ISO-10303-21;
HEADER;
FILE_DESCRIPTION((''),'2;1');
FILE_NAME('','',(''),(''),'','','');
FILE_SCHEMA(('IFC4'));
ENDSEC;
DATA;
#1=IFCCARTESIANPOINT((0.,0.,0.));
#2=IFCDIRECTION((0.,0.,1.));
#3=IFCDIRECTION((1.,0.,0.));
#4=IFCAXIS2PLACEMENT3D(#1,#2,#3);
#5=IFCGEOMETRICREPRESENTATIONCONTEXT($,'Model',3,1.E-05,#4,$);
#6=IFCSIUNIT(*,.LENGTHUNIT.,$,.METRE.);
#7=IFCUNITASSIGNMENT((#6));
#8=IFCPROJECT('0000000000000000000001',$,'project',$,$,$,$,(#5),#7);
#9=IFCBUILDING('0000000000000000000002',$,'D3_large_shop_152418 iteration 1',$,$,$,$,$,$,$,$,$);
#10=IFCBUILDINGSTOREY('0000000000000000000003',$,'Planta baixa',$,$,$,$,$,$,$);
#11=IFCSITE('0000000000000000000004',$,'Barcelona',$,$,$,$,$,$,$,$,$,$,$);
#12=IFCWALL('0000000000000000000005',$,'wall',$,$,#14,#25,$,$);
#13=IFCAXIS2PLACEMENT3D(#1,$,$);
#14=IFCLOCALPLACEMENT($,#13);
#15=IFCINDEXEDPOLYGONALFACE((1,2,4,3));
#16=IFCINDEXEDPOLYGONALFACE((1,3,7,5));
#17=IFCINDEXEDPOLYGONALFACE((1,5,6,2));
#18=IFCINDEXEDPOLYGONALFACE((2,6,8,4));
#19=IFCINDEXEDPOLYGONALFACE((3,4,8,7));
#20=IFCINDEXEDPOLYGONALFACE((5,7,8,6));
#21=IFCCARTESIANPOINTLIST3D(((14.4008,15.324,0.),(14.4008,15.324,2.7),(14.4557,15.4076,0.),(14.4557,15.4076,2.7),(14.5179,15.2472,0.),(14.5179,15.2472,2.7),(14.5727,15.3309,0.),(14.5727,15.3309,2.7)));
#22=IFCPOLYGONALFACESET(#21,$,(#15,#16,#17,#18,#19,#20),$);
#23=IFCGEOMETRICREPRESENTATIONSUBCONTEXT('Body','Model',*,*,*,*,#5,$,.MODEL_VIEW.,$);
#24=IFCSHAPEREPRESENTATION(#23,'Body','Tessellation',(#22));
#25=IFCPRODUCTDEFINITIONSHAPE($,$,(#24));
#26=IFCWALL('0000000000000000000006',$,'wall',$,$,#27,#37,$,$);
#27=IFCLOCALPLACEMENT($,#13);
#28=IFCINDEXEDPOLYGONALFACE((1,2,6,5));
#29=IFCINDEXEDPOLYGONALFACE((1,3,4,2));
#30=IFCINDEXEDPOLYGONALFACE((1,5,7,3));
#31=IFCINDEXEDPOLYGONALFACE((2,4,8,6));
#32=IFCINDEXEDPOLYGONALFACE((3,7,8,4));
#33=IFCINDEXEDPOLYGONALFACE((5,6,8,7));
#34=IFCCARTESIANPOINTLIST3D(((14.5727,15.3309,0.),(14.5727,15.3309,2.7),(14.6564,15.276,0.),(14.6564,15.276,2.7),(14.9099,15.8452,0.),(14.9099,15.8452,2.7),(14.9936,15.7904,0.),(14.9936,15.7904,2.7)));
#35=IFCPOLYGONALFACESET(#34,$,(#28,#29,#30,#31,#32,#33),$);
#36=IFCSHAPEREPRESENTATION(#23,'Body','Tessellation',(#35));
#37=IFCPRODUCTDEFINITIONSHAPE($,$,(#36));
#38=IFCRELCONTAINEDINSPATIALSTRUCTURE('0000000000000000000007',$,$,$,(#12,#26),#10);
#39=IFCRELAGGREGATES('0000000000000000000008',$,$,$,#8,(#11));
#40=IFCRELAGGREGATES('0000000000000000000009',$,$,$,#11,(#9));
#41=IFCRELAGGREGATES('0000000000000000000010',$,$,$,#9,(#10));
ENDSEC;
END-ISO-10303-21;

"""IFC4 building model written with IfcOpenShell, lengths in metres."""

from ifc_helpers import new_model, si_unit, origin, origin_with_axes, place, context, subcontext, project, spatial, polyline, outline, extrude, element, save


model = new_model("IFC4")

# Units and contexts
model_context = context("Model", 3, precision=1e-05, world=origin_with_axes())
body_context = subcontext(model_context, "Body", "Model", "MODEL_VIEW")
ifc_project = project(units=[si_unit("LENGTHUNIT", "METRE")], contexts=[model_context])

# Site, building, storey
site = spatial("IfcSite", under=ifc_project, Name="Barcelona")
building = spatial("IfcBuilding", under=site, Name="D3_large_shop_152418 iteration 1")
storey = spatial("IfcBuildingStorey", under=building, Name="Planta baixa")

# Walls
wall_1_placement = place(None, origin_with_axes())
element("IfcWall", 1, at=wall_1_placement, inside=storey, Name="wall", context=body_context, shape_type="SweptSolid", body=[
    extrude(outline(polyline([(14.4557, 15.4076), (14.5727, 15.3309), (14.5179, 15.2472), (14.4008, 15.324), (14.4557, 15.4076)])), origin(), (0.0, 0.0, 1.0), 2.7),
])
wall_2_placement = place(None, origin_with_axes())
element("IfcWall", 2, at=wall_2_placement, inside=storey, Name="wall", context=body_context, shape_type="SweptSolid", body=[
    extrude(outline(polyline([(14.5727, 15.3309), (14.9099, 15.8452), (14.9936, 15.7904), (14.6564, 15.276), (14.5727, 15.3309)])), origin(), (0.0, 0.0, 1.0), 2.7),
])

save(model, "model.ifc")
